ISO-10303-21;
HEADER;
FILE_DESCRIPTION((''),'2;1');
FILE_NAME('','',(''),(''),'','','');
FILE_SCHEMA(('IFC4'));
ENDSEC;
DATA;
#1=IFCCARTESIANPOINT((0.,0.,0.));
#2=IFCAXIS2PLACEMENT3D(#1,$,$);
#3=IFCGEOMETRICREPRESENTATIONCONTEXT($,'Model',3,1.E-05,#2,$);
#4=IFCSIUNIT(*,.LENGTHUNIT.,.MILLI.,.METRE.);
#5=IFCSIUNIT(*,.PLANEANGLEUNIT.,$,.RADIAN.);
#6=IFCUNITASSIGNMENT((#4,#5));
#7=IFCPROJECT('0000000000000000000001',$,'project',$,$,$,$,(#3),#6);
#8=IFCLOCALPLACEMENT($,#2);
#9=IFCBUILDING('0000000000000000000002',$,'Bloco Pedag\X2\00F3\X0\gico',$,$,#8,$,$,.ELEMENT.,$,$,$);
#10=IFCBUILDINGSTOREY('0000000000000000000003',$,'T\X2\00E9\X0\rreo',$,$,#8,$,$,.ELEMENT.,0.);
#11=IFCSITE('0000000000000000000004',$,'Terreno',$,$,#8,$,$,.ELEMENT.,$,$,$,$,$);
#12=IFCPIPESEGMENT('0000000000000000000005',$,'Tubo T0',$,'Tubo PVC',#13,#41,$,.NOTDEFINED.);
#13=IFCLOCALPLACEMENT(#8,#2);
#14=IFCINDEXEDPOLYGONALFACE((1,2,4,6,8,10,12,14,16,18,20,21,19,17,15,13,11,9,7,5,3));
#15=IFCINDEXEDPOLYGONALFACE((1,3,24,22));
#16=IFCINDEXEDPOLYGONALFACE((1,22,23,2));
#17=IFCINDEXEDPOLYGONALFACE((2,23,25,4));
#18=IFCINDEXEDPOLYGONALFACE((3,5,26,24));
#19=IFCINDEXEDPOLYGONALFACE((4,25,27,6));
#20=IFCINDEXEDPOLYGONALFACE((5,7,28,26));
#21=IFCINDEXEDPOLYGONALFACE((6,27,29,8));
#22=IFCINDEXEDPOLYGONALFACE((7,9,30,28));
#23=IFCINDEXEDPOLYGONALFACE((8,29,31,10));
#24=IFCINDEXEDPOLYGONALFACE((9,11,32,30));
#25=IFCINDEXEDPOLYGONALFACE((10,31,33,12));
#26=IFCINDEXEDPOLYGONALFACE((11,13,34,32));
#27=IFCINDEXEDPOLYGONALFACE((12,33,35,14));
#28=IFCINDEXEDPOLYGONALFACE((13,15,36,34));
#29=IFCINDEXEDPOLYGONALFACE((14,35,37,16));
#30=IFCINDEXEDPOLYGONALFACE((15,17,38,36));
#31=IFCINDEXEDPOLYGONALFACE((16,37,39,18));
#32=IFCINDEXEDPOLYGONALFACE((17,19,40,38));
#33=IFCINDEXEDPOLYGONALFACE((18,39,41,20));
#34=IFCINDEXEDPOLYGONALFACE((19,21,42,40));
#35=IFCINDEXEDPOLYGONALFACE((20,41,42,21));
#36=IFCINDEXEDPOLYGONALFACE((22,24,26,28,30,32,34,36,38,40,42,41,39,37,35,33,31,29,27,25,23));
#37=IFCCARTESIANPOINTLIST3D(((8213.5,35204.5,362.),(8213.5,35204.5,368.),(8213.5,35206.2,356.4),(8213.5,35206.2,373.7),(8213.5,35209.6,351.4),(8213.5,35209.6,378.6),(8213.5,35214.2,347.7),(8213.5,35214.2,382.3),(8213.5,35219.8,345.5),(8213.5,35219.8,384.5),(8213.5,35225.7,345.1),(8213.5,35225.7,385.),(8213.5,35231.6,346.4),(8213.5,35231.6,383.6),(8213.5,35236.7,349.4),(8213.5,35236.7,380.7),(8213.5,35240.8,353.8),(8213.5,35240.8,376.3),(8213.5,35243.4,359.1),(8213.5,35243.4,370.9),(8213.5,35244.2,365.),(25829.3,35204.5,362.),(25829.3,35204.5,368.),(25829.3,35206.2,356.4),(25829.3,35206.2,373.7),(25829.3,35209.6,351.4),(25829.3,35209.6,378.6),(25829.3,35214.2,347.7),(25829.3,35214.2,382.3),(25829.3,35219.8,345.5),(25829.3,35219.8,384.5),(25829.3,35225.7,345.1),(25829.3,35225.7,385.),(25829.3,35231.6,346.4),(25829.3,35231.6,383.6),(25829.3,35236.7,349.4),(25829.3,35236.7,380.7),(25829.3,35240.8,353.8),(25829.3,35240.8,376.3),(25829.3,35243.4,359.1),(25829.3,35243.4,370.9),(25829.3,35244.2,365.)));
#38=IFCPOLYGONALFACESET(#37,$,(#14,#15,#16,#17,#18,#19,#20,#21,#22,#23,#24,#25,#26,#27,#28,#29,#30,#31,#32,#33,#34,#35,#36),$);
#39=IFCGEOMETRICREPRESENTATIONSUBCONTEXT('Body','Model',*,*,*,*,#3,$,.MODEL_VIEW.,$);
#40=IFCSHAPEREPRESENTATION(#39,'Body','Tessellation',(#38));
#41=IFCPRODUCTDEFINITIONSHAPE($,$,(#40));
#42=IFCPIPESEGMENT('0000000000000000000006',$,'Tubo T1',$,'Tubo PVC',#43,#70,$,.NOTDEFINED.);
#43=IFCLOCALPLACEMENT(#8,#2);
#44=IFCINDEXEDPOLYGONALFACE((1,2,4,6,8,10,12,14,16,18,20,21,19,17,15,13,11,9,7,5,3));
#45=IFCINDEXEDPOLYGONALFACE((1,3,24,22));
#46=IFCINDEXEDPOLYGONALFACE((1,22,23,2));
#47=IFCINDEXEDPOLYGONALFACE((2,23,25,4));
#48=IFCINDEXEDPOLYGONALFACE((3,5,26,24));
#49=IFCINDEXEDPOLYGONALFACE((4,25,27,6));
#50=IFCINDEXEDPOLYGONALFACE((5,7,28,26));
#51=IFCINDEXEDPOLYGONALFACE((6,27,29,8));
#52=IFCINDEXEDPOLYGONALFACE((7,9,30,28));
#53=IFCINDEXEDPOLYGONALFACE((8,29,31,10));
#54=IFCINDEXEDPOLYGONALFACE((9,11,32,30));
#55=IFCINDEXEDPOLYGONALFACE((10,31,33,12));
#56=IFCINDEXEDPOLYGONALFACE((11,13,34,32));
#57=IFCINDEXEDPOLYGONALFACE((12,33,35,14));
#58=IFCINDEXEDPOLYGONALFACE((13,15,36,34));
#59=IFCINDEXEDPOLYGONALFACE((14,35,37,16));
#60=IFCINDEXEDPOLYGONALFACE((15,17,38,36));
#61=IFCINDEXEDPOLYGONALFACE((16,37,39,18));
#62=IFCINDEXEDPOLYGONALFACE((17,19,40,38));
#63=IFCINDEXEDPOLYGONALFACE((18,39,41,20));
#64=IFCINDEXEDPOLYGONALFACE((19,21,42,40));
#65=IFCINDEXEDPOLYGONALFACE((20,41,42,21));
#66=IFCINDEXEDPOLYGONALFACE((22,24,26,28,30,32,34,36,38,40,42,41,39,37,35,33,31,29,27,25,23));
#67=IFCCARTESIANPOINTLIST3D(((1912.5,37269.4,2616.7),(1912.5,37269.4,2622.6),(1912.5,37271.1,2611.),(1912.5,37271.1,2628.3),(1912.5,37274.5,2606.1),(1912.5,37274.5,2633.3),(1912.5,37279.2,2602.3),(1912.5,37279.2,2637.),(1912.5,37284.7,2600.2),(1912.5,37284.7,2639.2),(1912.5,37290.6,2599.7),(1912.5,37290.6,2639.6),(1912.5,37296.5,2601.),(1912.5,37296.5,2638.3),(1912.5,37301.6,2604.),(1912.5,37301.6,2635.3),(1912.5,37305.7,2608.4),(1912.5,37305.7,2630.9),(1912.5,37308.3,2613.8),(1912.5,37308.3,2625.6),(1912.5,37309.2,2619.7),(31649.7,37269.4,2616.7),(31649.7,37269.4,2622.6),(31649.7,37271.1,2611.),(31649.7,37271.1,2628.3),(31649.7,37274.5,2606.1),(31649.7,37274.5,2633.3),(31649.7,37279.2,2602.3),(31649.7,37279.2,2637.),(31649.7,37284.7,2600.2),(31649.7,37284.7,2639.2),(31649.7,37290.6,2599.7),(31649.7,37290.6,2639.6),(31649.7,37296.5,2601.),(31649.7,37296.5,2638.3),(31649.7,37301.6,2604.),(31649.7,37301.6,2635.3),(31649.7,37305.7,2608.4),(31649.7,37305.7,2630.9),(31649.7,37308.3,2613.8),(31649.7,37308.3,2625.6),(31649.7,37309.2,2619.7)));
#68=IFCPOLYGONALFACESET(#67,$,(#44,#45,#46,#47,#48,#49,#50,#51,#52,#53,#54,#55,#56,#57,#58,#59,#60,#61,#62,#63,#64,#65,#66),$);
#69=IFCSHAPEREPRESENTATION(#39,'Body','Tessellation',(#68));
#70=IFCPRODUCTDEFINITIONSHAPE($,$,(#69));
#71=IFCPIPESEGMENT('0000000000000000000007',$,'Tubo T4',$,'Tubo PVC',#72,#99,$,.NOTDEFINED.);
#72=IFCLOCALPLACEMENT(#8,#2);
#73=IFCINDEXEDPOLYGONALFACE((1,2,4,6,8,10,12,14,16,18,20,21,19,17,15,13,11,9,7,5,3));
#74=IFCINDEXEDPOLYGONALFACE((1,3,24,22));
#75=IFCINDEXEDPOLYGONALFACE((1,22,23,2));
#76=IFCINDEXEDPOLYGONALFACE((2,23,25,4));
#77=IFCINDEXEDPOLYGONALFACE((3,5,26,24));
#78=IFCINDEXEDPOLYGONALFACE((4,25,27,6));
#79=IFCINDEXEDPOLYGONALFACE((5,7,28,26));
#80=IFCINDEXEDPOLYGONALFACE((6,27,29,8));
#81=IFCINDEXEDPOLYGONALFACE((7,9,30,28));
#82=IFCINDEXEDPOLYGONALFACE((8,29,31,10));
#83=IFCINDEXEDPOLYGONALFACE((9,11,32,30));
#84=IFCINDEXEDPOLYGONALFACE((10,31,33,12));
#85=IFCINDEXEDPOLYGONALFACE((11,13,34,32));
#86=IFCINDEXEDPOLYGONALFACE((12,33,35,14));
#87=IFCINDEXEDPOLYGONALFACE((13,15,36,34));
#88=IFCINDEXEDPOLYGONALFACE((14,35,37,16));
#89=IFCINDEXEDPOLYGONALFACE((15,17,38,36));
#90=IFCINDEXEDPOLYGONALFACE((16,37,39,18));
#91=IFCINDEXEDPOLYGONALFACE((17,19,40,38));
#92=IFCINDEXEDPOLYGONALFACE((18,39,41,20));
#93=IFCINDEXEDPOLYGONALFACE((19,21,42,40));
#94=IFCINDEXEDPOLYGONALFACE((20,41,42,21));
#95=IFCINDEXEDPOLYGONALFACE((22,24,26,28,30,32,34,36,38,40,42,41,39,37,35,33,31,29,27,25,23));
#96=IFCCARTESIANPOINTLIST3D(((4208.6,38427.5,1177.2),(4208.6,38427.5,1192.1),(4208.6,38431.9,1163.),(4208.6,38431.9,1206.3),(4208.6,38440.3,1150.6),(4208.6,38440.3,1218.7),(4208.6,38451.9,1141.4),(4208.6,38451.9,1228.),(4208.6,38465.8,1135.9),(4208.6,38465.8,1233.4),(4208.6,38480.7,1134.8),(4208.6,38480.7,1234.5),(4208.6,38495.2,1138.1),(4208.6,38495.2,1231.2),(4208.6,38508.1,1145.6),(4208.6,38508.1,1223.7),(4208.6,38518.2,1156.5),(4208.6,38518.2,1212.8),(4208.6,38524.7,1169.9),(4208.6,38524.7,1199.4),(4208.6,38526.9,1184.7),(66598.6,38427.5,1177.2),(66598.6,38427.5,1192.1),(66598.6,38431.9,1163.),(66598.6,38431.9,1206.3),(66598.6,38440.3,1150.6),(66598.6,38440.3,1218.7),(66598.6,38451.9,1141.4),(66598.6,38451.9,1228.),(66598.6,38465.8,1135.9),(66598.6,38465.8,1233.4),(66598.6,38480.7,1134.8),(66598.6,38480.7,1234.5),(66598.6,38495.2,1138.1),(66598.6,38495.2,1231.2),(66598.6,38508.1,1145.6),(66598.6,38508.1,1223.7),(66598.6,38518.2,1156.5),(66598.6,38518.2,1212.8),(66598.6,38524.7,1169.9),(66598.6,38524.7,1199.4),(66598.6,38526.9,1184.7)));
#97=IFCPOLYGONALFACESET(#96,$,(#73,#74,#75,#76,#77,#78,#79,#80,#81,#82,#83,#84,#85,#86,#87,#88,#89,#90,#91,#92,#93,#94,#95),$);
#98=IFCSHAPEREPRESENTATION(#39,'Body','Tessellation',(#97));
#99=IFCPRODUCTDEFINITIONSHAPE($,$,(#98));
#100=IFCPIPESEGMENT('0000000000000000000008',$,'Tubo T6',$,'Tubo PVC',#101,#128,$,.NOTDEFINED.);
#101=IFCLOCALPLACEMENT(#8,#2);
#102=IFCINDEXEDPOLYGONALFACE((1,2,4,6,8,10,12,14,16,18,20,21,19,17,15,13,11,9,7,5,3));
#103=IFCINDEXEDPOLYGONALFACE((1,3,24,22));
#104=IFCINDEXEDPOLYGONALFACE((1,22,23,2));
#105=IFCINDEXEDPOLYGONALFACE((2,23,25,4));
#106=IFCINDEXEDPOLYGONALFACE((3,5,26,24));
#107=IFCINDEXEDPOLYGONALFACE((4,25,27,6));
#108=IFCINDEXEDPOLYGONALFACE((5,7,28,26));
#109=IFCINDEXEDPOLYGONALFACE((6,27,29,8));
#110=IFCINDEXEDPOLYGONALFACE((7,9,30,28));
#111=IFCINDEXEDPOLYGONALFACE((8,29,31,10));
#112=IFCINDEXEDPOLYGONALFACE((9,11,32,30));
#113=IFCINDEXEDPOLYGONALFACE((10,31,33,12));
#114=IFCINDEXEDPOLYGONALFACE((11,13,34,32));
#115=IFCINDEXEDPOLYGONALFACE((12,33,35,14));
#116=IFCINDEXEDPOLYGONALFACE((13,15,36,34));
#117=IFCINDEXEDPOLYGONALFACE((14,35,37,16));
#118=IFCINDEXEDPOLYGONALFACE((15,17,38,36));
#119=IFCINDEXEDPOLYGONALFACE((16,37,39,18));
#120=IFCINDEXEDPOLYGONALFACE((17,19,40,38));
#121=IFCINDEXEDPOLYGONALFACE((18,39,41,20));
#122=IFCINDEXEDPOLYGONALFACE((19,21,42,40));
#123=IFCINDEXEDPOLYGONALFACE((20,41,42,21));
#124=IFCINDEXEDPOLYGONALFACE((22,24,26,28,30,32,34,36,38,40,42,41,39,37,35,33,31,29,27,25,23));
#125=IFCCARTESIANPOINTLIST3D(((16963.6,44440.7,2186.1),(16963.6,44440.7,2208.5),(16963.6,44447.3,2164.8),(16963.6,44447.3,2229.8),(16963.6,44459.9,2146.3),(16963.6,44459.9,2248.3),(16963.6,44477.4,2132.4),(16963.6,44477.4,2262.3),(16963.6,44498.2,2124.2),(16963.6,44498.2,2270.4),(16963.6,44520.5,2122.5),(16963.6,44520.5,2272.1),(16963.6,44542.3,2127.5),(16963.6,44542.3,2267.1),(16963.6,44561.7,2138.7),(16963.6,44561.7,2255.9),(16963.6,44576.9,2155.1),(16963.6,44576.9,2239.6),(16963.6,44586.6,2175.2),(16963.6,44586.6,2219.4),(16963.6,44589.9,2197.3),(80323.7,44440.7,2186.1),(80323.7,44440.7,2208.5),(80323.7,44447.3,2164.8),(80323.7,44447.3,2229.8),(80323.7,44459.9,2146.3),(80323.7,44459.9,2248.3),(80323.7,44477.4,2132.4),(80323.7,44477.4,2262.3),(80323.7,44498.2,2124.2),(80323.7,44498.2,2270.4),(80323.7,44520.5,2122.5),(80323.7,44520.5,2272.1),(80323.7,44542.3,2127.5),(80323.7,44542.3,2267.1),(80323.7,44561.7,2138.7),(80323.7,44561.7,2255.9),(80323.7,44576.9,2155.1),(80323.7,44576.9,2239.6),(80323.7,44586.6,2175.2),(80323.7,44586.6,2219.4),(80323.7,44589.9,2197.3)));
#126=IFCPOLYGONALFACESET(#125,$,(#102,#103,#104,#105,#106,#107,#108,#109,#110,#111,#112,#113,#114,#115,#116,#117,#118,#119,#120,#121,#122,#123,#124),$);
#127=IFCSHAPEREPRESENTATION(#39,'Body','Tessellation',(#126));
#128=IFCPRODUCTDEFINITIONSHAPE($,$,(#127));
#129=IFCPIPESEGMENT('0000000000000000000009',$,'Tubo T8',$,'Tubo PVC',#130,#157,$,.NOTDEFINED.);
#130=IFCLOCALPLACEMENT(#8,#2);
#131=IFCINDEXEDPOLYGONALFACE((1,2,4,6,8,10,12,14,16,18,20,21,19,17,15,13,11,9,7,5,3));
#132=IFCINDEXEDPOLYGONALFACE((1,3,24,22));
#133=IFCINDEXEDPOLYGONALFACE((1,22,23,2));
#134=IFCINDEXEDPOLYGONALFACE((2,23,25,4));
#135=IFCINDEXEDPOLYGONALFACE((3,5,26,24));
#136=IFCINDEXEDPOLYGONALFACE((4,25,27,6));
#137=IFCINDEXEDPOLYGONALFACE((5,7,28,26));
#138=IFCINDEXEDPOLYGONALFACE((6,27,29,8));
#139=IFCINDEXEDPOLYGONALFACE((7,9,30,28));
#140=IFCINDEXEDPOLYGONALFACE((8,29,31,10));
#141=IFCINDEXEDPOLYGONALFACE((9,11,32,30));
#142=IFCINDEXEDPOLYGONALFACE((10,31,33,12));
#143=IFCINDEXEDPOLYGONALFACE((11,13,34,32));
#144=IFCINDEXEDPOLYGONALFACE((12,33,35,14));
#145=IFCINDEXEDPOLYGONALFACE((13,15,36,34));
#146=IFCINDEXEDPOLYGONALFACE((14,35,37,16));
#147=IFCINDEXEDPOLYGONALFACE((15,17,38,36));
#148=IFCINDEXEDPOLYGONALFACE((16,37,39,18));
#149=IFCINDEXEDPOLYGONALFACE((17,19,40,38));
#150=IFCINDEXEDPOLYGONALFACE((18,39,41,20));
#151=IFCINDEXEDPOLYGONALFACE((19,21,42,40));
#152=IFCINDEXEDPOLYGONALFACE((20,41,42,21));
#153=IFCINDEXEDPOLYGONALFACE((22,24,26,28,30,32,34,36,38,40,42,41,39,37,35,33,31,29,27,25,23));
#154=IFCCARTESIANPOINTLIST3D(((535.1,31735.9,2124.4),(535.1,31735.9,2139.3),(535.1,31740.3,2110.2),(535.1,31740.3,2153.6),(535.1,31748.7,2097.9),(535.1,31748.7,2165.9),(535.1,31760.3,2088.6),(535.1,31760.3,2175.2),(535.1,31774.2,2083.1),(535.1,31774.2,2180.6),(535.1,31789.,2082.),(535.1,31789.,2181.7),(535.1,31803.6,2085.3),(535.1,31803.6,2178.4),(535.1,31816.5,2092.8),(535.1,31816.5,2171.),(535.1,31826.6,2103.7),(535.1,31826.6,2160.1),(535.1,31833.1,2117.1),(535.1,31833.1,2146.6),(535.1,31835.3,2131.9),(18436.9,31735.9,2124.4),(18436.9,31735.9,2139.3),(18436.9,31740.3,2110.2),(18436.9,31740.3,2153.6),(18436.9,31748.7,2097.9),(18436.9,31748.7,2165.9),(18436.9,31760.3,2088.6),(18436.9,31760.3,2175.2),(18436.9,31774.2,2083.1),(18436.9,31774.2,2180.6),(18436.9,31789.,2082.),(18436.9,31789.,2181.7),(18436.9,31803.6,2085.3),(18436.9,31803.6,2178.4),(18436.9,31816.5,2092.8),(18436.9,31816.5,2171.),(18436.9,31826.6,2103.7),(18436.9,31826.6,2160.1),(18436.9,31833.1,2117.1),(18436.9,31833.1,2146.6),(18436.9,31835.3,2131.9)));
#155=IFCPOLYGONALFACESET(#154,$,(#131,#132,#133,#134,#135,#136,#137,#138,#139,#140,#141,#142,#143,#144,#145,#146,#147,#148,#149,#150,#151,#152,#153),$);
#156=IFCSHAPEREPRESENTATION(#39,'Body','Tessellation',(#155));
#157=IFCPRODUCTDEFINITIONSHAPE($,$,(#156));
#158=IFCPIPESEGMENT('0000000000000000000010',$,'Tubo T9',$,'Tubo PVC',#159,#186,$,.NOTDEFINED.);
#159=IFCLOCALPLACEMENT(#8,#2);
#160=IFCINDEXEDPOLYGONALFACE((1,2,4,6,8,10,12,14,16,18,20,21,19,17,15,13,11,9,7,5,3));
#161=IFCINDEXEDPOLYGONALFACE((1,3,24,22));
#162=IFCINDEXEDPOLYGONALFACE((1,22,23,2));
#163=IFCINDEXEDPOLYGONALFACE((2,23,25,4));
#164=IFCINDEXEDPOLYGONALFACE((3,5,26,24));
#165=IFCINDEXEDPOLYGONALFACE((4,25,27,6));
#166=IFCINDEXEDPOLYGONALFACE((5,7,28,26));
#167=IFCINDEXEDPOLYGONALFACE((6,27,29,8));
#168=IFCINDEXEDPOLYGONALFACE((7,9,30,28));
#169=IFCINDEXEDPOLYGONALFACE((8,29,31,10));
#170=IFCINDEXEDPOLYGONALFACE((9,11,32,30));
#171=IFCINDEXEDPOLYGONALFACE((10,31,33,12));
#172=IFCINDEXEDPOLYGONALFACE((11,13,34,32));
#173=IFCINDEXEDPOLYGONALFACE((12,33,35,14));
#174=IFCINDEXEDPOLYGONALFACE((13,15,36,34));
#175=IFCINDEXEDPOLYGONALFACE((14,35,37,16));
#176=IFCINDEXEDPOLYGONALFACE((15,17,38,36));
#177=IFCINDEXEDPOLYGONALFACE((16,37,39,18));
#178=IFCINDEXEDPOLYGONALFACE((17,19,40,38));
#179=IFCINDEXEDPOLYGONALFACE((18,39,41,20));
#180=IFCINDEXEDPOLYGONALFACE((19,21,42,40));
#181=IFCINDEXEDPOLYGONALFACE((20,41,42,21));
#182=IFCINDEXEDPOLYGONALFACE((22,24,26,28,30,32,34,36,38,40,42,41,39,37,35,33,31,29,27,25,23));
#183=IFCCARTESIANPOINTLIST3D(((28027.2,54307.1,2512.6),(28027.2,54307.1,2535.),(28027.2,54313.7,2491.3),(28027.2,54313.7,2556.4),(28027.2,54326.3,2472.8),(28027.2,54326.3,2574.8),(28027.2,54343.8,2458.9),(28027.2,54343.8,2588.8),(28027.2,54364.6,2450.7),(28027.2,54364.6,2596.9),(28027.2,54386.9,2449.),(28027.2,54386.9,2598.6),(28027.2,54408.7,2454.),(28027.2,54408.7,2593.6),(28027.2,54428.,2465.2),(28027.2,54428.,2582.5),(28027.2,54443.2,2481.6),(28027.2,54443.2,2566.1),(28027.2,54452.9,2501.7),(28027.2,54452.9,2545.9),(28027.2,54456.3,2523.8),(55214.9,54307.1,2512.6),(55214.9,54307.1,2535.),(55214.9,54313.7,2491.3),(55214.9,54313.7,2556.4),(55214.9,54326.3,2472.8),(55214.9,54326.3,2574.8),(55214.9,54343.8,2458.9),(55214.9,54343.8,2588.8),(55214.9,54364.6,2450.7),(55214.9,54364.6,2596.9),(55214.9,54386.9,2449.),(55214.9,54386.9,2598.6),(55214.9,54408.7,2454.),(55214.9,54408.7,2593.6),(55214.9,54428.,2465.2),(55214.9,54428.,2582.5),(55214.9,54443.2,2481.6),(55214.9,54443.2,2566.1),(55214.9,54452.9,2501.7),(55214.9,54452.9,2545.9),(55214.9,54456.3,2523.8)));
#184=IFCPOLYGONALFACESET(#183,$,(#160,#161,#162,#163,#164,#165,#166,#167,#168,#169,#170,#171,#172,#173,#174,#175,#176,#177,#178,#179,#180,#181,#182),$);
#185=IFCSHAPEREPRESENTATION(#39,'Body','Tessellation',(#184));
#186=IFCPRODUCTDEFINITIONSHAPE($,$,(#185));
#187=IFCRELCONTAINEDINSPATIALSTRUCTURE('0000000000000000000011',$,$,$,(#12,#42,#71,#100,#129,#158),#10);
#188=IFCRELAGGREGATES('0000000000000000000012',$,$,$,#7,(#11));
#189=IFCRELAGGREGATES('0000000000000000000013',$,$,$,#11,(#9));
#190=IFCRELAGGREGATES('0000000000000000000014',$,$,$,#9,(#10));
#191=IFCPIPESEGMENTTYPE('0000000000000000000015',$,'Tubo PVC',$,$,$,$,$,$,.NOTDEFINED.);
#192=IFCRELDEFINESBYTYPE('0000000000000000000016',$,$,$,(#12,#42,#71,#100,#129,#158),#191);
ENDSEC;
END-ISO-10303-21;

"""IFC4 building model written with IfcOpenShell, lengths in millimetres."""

from ifc_helpers import new_model, si_unit, frame, origin, origin_2d, place, context, subcontext, project, spatial, circle, extrude, type_object, element, save


model = new_model("IFC4")

# Units and contexts
model_context = context("Model", 3, precision=1e-05, world=origin())
body_context = subcontext(model_context, "Body", "Model", "MODEL_VIEW")
ifc_project = project(units=[si_unit("LENGTHUNIT", "METRE", prefix="MILLI"), si_unit("PLANEANGLEUNIT", "RADIAN")], contexts=[model_context])

# Site, building, storey
placement = place(None, origin())
site = spatial("IfcSite", under=ifc_project, at=placement, Name="Terreno", CompositionType="ELEMENT")
building = spatial("IfcBuilding", under=site, at=placement, Name="Bloco Pedagógico", CompositionType="ELEMENT")
storey = spatial("IfcBuildingStorey", under=building, at=placement, Name="Térreo", CompositionType="ELEMENT", Elevation=0.0)

# Pipe segments
pipe_segment_type = type_object("IfcPipeSegmentType", Name="Tubo PVC", PredefinedType="NOTDEFINED")
pipe_segment_1_placement = place(None, frame((8213.5, 35224.2, 365.0), z_axis=(1.0, 0.0, 0.0), x_axis=(0.0, 1.0, 0.0)))
element("IfcPipeSegment", 1, at=pipe_segment_1_placement, inside=storey, type_object=pipe_segment_type, Name="Tubo T0", ObjectType="Tubo PVC", PredefinedType="NOTDEFINED", context=body_context, shape_type="SweptSolid", body=[
    extrude(circle(Radius=20.0, at=origin_2d()), None, (0.0, 0.0, 1.0), 17615.9),
])
pipe_segment_2_placement = place(None, frame((1912.5, 37289.2, 2619.7), z_axis=(1.0, 0.0, 0.0), x_axis=(0.0, 1.0, 0.0)))
element("IfcPipeSegment", 2, at=pipe_segment_2_placement, inside=storey, type_object=pipe_segment_type, Name="Tubo T1", ObjectType="Tubo PVC", PredefinedType="NOTDEFINED", context=body_context, shape_type="SweptSolid", body=[
    extrude(circle(Radius=20.0, at=origin_2d()), None, (0.0, 0.0, 1.0), 29737.2),
])
pipe_segment_3_placement = place(None, frame((4208.6, 38476.9, 1184.7), z_axis=(1.0, 0.0, 0.0), x_axis=(0.0, 1.0, 0.0)))
element("IfcPipeSegment", 3, at=pipe_segment_3_placement, inside=storey, type_object=pipe_segment_type, Name="Tubo T4", ObjectType="Tubo PVC", PredefinedType="NOTDEFINED", context=body_context, shape_type="SweptSolid", body=[
    extrude(circle(Radius=50.0, at=origin_2d()), None, (0.0, 0.0, 1.0), 62390.0),
])
pipe_segment_4_placement = place(None, frame((16963.6, 44514.9, 2197.3), z_axis=(1.0, 0.0, 0.0), x_axis=(0.0, 1.0, 0.0)))
element("IfcPipeSegment", 4, at=pipe_segment_4_placement, inside=storey, type_object=pipe_segment_type, Name="Tubo T6", ObjectType="Tubo PVC", PredefinedType="NOTDEFINED", context=body_context, shape_type="SweptSolid", body=[
    extrude(circle(Radius=75.0, at=origin_2d()), None, (0.0, 0.0, 1.0), 63360.1),
])
pipe_segment_5_placement = place(None, frame((535.1, 31785.3, 2131.9), z_axis=(1.0, 0.0, 0.0), x_axis=(0.0, 1.0, 0.0)))
element("IfcPipeSegment", 5, at=pipe_segment_5_placement, inside=storey, type_object=pipe_segment_type, Name="Tubo T8", ObjectType="Tubo PVC", PredefinedType="NOTDEFINED", context=body_context, shape_type="SweptSolid", body=[
    extrude(circle(Radius=50.0, at=origin_2d()), None, (0.0, 0.0, 1.0), 17901.8),
])
pipe_segment_6_placement = place(None, frame((28027.2, 54381.3, 2523.8), z_axis=(1.0, 0.0, 0.0), x_axis=(0.0, 1.0, 0.0)))
element("IfcPipeSegment", 6, at=pipe_segment_6_placement, inside=storey, type_object=pipe_segment_type, Name="Tubo T9", ObjectType="Tubo PVC", PredefinedType="NOTDEFINED", context=body_context, shape_type="SweptSolid", body=[
    extrude(circle(Radius=75.0, at=origin_2d()), None, (0.0, 0.0, 1.0), 27187.7),
])

save(model, "model.ifc")
